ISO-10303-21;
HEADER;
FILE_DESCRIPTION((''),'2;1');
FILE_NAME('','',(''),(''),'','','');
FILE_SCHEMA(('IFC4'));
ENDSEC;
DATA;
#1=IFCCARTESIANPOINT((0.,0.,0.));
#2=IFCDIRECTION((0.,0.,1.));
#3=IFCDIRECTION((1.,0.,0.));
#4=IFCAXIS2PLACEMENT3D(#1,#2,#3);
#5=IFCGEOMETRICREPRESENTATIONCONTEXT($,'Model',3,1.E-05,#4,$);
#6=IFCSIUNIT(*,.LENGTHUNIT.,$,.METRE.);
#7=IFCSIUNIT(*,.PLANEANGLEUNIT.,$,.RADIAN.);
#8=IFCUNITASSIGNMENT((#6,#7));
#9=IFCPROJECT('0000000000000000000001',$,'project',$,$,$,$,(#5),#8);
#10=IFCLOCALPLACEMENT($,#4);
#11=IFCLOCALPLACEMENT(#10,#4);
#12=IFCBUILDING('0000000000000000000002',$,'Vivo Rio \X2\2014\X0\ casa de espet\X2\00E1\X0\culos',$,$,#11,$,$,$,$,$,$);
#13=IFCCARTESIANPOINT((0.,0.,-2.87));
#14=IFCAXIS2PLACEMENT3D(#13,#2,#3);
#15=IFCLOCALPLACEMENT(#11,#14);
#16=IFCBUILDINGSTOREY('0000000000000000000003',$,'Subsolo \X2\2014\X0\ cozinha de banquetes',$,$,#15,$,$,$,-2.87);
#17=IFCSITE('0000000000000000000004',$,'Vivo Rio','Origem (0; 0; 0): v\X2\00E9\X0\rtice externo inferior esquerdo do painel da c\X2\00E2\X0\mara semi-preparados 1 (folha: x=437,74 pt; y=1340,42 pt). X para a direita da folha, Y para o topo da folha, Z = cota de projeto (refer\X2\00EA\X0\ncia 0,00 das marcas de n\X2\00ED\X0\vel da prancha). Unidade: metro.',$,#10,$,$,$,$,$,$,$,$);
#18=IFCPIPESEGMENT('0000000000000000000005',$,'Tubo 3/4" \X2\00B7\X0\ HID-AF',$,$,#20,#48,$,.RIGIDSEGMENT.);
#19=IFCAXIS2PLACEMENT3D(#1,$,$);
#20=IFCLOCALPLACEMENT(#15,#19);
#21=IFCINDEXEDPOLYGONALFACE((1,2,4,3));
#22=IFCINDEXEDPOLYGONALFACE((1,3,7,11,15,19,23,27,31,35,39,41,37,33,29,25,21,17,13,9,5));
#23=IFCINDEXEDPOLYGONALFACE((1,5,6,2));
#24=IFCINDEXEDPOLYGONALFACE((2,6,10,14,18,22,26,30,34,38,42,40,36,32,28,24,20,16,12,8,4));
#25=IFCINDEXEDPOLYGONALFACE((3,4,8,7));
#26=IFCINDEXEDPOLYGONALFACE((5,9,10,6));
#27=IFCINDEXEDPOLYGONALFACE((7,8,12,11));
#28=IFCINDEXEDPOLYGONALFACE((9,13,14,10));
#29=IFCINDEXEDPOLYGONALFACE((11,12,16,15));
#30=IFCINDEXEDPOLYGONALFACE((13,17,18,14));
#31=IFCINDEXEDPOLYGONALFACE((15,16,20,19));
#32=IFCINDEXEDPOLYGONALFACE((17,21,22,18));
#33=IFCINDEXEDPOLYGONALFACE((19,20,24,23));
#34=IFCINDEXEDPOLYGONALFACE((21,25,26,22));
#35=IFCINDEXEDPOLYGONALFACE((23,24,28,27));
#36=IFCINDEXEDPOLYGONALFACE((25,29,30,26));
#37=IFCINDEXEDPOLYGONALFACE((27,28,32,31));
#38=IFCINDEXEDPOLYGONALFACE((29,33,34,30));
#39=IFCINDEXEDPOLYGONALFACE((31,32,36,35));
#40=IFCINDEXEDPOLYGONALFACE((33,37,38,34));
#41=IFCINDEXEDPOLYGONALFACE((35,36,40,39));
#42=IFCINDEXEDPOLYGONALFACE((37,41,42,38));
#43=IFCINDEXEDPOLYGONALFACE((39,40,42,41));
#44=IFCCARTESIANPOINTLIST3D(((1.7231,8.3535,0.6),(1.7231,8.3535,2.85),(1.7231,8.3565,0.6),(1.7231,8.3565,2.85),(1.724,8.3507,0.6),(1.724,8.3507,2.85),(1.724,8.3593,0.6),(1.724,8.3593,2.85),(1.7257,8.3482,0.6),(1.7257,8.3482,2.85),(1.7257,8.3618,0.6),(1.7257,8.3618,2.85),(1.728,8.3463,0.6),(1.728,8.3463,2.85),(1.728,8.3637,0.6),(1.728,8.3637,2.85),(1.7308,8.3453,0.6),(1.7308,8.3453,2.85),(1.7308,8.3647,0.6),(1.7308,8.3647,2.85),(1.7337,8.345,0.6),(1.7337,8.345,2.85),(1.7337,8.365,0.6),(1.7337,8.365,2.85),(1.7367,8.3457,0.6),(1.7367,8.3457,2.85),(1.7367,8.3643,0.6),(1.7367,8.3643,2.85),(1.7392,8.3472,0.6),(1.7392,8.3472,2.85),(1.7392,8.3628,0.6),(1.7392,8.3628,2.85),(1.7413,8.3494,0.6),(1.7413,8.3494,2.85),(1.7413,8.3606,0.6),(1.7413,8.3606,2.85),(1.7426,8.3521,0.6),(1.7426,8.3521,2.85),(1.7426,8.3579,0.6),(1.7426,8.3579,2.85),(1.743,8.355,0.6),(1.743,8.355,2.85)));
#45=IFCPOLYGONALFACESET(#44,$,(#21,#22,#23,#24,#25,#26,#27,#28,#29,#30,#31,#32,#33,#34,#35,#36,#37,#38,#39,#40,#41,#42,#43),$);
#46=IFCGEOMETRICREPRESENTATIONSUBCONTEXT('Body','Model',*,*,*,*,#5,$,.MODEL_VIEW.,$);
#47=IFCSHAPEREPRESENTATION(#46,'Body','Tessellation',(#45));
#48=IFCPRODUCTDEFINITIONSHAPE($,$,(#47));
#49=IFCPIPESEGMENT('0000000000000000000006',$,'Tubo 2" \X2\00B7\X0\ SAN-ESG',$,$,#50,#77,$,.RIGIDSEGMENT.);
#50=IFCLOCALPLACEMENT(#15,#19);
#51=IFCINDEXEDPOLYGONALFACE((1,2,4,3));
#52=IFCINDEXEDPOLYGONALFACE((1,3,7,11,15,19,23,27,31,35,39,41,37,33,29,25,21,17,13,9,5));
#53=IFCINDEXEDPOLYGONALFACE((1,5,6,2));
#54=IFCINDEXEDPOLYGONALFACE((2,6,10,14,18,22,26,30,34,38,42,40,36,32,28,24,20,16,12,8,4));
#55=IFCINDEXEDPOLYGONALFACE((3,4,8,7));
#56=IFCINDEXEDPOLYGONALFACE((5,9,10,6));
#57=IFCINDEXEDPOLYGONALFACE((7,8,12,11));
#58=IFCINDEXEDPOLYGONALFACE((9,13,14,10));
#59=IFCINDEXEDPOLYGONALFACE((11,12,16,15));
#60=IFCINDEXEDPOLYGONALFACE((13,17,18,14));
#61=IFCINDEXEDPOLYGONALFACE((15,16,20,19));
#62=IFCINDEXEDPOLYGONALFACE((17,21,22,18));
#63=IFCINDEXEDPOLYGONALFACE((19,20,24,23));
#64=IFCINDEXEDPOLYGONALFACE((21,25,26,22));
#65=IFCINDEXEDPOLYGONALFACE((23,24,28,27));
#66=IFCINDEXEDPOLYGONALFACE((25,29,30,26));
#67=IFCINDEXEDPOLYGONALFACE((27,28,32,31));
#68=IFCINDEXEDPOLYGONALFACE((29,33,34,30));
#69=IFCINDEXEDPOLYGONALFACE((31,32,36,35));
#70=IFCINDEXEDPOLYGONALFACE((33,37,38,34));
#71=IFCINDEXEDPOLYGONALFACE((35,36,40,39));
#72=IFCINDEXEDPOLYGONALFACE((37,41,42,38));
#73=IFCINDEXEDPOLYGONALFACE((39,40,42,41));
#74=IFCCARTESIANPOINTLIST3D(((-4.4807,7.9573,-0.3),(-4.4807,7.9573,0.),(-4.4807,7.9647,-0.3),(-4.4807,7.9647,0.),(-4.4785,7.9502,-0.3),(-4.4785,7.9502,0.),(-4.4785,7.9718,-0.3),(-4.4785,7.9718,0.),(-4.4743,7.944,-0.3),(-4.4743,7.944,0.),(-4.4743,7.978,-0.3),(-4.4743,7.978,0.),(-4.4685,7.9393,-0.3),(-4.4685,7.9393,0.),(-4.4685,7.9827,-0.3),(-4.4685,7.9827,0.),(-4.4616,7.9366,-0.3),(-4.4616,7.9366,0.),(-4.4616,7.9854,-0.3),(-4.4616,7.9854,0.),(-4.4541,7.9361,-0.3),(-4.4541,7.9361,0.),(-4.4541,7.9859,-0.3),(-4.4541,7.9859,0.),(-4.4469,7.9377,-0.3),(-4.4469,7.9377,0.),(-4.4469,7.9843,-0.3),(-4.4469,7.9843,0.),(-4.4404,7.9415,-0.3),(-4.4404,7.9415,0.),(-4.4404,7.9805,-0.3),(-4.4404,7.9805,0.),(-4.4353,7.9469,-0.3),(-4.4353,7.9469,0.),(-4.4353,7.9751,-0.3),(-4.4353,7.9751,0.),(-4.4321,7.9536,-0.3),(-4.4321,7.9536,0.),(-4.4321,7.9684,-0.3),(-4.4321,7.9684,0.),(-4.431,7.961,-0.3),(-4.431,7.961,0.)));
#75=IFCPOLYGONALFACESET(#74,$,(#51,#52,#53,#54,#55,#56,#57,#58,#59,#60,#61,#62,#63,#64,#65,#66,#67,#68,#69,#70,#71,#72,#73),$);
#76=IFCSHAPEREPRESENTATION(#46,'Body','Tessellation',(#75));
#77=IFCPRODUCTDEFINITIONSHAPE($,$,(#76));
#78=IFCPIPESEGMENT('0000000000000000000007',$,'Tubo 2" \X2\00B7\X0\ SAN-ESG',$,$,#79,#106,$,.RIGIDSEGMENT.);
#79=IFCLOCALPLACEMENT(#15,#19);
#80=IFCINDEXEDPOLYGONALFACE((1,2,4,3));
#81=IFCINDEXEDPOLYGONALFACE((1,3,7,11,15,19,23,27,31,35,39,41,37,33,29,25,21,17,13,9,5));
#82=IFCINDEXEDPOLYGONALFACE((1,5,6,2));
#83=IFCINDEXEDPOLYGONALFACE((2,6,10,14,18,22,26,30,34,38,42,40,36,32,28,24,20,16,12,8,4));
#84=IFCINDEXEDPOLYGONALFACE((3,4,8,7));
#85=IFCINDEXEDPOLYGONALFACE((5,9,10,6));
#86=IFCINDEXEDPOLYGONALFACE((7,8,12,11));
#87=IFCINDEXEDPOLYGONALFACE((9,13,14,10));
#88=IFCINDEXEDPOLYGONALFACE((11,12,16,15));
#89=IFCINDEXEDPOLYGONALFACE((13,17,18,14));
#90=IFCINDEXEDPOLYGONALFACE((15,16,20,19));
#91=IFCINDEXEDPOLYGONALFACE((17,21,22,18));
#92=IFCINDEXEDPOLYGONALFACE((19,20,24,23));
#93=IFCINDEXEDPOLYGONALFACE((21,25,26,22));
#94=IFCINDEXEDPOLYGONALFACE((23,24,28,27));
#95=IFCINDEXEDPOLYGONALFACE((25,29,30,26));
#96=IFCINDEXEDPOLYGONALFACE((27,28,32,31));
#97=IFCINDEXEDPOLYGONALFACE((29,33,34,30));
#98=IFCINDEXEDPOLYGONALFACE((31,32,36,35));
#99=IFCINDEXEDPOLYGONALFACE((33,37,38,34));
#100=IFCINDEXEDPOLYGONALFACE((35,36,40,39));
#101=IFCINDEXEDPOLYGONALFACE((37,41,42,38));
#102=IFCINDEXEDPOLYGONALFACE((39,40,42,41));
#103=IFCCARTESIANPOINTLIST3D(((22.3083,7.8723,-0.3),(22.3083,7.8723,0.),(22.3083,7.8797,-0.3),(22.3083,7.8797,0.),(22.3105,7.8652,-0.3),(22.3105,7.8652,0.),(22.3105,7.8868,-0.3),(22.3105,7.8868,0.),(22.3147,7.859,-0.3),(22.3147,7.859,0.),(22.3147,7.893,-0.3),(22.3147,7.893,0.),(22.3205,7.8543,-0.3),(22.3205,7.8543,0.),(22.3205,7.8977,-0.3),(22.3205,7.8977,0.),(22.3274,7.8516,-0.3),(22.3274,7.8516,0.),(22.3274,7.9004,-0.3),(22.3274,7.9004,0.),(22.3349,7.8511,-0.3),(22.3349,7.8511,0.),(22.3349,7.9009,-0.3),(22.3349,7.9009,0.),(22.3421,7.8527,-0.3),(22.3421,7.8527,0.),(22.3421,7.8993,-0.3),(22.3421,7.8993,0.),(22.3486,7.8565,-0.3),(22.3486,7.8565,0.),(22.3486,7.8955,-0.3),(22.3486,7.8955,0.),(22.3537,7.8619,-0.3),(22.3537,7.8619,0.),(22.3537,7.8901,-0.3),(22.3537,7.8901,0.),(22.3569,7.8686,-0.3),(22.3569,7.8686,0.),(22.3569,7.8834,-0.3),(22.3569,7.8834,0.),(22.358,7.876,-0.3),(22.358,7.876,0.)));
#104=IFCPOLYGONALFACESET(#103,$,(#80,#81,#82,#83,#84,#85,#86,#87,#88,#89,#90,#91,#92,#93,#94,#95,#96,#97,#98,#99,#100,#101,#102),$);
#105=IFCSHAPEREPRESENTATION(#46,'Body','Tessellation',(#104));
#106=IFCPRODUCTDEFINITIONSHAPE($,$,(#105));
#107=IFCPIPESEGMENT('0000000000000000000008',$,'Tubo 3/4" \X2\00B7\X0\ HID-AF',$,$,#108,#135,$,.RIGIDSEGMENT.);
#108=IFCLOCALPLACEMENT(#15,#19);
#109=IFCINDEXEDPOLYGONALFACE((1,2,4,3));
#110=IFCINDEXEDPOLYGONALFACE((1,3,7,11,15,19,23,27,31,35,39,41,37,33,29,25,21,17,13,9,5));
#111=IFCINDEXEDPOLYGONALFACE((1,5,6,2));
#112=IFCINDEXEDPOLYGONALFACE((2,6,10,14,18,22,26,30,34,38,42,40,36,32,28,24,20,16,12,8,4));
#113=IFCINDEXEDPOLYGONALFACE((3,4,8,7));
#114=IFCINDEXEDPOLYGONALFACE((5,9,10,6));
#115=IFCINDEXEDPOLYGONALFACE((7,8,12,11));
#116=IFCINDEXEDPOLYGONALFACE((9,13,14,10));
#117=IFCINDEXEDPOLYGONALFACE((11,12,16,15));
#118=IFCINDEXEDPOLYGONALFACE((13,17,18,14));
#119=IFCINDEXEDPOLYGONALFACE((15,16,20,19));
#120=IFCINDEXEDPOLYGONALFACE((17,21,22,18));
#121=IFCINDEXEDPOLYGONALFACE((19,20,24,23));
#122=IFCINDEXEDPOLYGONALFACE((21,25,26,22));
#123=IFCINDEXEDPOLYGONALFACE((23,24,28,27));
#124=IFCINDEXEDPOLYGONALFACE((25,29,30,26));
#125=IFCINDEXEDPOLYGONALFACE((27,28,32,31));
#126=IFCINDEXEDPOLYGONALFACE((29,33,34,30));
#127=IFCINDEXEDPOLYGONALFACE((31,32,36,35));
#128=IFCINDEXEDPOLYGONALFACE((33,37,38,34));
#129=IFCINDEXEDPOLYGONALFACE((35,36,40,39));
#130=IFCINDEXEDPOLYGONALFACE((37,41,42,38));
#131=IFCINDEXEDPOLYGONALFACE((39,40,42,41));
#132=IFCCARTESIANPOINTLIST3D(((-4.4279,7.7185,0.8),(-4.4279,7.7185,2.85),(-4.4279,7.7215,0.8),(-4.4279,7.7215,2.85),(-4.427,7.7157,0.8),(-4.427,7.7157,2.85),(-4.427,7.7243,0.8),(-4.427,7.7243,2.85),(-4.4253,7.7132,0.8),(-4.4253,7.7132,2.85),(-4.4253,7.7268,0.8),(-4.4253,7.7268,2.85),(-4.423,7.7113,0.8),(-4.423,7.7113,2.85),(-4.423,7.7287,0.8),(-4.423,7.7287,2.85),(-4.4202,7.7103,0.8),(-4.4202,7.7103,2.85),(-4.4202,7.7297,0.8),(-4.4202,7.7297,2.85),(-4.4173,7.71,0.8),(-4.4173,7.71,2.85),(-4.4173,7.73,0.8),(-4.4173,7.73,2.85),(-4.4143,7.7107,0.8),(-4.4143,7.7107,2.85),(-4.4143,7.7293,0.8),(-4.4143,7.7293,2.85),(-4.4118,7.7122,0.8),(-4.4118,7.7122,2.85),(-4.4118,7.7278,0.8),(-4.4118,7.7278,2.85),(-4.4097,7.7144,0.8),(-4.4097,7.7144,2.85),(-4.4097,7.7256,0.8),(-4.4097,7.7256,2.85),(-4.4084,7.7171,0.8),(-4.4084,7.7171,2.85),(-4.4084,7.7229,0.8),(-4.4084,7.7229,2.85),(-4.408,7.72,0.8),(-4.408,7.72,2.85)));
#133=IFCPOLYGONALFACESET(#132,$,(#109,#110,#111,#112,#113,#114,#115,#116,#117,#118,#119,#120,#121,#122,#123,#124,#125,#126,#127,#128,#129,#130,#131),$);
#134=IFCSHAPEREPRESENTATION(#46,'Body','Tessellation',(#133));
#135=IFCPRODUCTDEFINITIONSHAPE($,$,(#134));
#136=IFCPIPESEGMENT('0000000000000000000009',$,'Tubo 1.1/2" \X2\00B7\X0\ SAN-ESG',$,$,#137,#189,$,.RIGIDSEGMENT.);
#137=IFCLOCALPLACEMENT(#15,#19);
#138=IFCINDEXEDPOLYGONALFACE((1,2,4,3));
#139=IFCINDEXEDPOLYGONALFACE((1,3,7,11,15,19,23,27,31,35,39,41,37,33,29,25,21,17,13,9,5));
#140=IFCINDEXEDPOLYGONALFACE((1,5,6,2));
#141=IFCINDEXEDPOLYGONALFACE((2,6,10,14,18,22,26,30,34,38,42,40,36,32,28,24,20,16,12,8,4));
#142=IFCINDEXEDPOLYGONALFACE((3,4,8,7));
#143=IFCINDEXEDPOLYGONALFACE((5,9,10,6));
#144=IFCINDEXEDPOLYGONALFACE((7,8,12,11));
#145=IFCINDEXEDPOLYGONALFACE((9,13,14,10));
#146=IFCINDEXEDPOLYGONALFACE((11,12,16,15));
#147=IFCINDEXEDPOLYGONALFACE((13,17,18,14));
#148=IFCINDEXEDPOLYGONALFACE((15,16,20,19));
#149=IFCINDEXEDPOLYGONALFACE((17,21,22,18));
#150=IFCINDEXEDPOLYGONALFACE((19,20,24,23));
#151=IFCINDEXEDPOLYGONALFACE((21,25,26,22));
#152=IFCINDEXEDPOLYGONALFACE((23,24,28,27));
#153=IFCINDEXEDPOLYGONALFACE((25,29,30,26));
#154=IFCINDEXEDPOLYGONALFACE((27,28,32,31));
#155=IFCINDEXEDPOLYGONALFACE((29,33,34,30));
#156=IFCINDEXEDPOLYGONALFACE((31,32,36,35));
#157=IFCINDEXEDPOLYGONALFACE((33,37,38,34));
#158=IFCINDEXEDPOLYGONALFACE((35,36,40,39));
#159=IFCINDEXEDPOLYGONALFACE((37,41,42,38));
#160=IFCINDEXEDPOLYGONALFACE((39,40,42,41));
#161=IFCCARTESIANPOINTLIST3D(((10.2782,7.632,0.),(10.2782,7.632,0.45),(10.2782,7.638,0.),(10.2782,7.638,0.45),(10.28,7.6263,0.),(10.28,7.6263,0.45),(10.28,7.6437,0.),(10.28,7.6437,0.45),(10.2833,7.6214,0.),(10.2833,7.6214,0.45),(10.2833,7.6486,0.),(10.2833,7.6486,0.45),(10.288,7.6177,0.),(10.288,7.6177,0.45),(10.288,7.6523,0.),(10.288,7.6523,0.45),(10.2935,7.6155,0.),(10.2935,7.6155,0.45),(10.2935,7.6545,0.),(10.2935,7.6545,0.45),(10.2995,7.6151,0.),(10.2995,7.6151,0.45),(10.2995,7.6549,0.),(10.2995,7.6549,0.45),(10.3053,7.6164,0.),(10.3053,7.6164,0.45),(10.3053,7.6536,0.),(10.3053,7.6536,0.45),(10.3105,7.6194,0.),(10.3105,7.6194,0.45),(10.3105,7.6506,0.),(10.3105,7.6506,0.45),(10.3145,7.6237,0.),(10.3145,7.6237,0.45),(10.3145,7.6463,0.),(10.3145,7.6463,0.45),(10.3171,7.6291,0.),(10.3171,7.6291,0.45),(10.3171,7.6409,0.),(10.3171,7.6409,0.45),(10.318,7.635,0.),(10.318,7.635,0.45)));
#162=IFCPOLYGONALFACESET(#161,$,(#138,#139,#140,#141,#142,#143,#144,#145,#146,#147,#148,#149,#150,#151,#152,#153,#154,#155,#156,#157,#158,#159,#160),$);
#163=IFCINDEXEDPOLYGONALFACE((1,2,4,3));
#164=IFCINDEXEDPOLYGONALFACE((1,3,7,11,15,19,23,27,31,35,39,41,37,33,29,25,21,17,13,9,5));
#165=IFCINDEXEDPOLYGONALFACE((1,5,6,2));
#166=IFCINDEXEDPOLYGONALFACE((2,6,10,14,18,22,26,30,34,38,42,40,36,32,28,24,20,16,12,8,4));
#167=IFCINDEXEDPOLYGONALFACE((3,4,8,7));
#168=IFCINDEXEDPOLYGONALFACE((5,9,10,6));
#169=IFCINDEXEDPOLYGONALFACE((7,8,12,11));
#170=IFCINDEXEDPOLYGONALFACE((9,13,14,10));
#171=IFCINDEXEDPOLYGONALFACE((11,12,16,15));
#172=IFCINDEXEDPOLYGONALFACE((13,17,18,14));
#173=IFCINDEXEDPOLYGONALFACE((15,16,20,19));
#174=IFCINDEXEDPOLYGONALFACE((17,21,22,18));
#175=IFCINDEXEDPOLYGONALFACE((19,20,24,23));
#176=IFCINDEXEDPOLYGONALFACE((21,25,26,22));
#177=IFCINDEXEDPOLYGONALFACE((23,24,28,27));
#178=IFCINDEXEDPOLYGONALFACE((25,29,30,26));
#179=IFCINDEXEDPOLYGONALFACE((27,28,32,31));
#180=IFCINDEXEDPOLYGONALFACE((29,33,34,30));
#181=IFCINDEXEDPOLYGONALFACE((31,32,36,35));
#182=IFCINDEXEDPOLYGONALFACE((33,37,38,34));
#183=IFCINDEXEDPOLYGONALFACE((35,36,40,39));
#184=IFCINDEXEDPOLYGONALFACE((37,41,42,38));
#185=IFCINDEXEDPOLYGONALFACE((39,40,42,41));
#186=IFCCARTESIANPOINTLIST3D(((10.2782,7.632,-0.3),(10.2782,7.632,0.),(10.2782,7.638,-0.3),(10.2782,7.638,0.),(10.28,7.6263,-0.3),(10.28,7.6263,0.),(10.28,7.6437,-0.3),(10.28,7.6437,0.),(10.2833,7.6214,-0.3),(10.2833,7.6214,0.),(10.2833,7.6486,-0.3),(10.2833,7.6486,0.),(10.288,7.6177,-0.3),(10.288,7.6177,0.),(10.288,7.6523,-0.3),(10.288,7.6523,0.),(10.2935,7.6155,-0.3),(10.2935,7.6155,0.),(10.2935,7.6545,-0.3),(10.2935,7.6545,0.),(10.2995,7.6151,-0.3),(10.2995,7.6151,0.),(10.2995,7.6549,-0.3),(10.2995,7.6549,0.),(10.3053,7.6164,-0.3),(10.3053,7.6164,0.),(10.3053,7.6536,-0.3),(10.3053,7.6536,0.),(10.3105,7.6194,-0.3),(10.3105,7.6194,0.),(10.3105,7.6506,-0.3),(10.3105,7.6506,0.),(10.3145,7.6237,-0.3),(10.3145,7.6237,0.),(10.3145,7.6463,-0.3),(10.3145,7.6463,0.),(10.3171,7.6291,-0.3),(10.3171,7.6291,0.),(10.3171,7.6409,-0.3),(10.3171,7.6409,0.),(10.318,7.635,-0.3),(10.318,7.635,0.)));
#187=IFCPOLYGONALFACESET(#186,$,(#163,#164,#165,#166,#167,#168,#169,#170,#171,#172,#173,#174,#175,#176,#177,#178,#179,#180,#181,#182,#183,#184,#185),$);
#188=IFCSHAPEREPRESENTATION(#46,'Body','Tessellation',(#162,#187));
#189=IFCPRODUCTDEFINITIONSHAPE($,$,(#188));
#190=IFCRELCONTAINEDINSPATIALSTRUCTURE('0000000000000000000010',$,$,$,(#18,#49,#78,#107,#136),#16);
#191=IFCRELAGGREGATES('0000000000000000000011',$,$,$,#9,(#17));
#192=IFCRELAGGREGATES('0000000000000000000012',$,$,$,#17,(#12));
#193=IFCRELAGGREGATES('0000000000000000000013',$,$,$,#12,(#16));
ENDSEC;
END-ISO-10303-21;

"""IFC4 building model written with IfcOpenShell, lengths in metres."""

from ifc_helpers import new_model, si_unit, frame, origin_with_axes, origin_2d, place, context, subcontext, project, spatial, circle, extrude, element, save


model = new_model("IFC4")

# Units and contexts
model_context = context("Model", 3, precision=1e-05, world=origin_with_axes())
body_context = subcontext(model_context, "Body", "Model", "MODEL_VIEW")
ifc_project = project(units=[si_unit("LENGTHUNIT", "METRE"), si_unit("PLANEANGLEUNIT", "RADIAN")], contexts=[model_context])

# Site, building, storey
site_placement = place(None, origin_with_axes())
site = spatial("IfcSite", under=ifc_project, at=site_placement, Name="Vivo Rio", Description="Origem (0; 0; 0): vértice externo inferior esquerdo do painel da câmara semi-preparados 1 (folha: x=437,74 pt; y=1340,42 pt). X para a direita da folha, Y para o topo da folha, Z = cota de projeto (referência 0,00 das marcas de nível da prancha). Unidade: metro.")
building_placement = place(site_placement, origin_with_axes())
building = spatial("IfcBuilding", under=site, at=building_placement, Name="Vivo Rio — casa de espetáculos")
storey_placement = place(building_placement, frame((0.0, 0.0, -2.87), z_axis=(0.0, 0.0, 1.0), x_axis=(1.0, 0.0, 0.0)))
storey = spatial("IfcBuildingStorey", under=building, at=storey_placement, Name="Subsolo — cozinha de banquetes", Elevation=-2.87)

# Pipe segments
pipe_segment_1_placement = place(storey_placement, origin_with_axes())
element("IfcPipeSegment", 1, at=pipe_segment_1_placement, inside=storey, Name="Tubo 3/4\" · HID-AF", PredefinedType="RIGIDSEGMENT", context=body_context, shape_type="SweptSolid", body=[
    extrude(circle(Radius=0.01, at=origin_2d()), frame((1.733, 8.355, 2.85), z_axis=(0.0, 0.0, -1.0), x_axis=(1.0, 0.0, 0.0)), (0.0, 0.0, 1.0), 2.25),
])
pipe_segment_2_placement = place(storey_placement, origin_with_axes())
element("IfcPipeSegment", 2, at=pipe_segment_2_placement, inside=storey, Name="Tubo 2\" · SAN-ESG", PredefinedType="RIGIDSEGMENT", context=body_context, shape_type="SweptSolid", body=[
    extrude(circle(Radius=0.025, at=origin_2d()), frame((-4.456, 7.961, 0.0), z_axis=(0.0, 0.0, -1.0), x_axis=(1.0, 0.0, 0.0)), (0.0, 0.0, 1.0), 0.3),
])
pipe_segment_3_placement = place(storey_placement, origin_with_axes())
element("IfcPipeSegment", 3, at=pipe_segment_3_placement, inside=storey, Name="Tubo 2\" · SAN-ESG", PredefinedType="RIGIDSEGMENT", context=body_context, shape_type="SweptSolid", body=[
    extrude(circle(Radius=0.025, at=origin_2d()), frame((22.333, 7.876, 0.0), z_axis=(0.0, 0.0, -1.0), x_axis=(1.0, 0.0, 0.0)), (0.0, 0.0, 1.0), 0.3),
])
pipe_segment_4_placement = place(storey_placement, origin_with_axes())
element("IfcPipeSegment", 4, at=pipe_segment_4_placement, inside=storey, Name="Tubo 3/4\" · HID-AF", PredefinedType="RIGIDSEGMENT", context=body_context, shape_type="SweptSolid", body=[
    extrude(circle(Radius=0.01, at=origin_2d()), frame((-4.418, 7.72, 2.85), z_axis=(0.0, 0.0, -1.0), x_axis=(1.0, 0.0, 0.0)), (0.0, 0.0, 1.0), 2.05),
])
pipe_segment_5_placement = place(storey_placement, origin_with_axes())
element("IfcPipeSegment", 5, at=pipe_segment_5_placement, inside=storey, Name="Tubo 1.1/2\" · SAN-ESG", PredefinedType="RIGIDSEGMENT", context=body_context, shape_type="SweptSolid", body=[
    extrude(circle(Radius=0.02, at=origin_2d()), frame((10.298, 7.635, 0.45), z_axis=(0.0, 0.0, -1.0), x_axis=(1.0, 0.0, 0.0)), (0.0, 0.0, 1.0), 0.45),
    extrude(circle(Radius=0.02, at=origin_2d()), frame((10.298, 7.635, 0.0), z_axis=(0.0, 0.0, -1.0), x_axis=(1.0, 0.0, 0.0)), (0.0, 0.0, 1.0), 0.3),
])

save(model, "model.ifc")
